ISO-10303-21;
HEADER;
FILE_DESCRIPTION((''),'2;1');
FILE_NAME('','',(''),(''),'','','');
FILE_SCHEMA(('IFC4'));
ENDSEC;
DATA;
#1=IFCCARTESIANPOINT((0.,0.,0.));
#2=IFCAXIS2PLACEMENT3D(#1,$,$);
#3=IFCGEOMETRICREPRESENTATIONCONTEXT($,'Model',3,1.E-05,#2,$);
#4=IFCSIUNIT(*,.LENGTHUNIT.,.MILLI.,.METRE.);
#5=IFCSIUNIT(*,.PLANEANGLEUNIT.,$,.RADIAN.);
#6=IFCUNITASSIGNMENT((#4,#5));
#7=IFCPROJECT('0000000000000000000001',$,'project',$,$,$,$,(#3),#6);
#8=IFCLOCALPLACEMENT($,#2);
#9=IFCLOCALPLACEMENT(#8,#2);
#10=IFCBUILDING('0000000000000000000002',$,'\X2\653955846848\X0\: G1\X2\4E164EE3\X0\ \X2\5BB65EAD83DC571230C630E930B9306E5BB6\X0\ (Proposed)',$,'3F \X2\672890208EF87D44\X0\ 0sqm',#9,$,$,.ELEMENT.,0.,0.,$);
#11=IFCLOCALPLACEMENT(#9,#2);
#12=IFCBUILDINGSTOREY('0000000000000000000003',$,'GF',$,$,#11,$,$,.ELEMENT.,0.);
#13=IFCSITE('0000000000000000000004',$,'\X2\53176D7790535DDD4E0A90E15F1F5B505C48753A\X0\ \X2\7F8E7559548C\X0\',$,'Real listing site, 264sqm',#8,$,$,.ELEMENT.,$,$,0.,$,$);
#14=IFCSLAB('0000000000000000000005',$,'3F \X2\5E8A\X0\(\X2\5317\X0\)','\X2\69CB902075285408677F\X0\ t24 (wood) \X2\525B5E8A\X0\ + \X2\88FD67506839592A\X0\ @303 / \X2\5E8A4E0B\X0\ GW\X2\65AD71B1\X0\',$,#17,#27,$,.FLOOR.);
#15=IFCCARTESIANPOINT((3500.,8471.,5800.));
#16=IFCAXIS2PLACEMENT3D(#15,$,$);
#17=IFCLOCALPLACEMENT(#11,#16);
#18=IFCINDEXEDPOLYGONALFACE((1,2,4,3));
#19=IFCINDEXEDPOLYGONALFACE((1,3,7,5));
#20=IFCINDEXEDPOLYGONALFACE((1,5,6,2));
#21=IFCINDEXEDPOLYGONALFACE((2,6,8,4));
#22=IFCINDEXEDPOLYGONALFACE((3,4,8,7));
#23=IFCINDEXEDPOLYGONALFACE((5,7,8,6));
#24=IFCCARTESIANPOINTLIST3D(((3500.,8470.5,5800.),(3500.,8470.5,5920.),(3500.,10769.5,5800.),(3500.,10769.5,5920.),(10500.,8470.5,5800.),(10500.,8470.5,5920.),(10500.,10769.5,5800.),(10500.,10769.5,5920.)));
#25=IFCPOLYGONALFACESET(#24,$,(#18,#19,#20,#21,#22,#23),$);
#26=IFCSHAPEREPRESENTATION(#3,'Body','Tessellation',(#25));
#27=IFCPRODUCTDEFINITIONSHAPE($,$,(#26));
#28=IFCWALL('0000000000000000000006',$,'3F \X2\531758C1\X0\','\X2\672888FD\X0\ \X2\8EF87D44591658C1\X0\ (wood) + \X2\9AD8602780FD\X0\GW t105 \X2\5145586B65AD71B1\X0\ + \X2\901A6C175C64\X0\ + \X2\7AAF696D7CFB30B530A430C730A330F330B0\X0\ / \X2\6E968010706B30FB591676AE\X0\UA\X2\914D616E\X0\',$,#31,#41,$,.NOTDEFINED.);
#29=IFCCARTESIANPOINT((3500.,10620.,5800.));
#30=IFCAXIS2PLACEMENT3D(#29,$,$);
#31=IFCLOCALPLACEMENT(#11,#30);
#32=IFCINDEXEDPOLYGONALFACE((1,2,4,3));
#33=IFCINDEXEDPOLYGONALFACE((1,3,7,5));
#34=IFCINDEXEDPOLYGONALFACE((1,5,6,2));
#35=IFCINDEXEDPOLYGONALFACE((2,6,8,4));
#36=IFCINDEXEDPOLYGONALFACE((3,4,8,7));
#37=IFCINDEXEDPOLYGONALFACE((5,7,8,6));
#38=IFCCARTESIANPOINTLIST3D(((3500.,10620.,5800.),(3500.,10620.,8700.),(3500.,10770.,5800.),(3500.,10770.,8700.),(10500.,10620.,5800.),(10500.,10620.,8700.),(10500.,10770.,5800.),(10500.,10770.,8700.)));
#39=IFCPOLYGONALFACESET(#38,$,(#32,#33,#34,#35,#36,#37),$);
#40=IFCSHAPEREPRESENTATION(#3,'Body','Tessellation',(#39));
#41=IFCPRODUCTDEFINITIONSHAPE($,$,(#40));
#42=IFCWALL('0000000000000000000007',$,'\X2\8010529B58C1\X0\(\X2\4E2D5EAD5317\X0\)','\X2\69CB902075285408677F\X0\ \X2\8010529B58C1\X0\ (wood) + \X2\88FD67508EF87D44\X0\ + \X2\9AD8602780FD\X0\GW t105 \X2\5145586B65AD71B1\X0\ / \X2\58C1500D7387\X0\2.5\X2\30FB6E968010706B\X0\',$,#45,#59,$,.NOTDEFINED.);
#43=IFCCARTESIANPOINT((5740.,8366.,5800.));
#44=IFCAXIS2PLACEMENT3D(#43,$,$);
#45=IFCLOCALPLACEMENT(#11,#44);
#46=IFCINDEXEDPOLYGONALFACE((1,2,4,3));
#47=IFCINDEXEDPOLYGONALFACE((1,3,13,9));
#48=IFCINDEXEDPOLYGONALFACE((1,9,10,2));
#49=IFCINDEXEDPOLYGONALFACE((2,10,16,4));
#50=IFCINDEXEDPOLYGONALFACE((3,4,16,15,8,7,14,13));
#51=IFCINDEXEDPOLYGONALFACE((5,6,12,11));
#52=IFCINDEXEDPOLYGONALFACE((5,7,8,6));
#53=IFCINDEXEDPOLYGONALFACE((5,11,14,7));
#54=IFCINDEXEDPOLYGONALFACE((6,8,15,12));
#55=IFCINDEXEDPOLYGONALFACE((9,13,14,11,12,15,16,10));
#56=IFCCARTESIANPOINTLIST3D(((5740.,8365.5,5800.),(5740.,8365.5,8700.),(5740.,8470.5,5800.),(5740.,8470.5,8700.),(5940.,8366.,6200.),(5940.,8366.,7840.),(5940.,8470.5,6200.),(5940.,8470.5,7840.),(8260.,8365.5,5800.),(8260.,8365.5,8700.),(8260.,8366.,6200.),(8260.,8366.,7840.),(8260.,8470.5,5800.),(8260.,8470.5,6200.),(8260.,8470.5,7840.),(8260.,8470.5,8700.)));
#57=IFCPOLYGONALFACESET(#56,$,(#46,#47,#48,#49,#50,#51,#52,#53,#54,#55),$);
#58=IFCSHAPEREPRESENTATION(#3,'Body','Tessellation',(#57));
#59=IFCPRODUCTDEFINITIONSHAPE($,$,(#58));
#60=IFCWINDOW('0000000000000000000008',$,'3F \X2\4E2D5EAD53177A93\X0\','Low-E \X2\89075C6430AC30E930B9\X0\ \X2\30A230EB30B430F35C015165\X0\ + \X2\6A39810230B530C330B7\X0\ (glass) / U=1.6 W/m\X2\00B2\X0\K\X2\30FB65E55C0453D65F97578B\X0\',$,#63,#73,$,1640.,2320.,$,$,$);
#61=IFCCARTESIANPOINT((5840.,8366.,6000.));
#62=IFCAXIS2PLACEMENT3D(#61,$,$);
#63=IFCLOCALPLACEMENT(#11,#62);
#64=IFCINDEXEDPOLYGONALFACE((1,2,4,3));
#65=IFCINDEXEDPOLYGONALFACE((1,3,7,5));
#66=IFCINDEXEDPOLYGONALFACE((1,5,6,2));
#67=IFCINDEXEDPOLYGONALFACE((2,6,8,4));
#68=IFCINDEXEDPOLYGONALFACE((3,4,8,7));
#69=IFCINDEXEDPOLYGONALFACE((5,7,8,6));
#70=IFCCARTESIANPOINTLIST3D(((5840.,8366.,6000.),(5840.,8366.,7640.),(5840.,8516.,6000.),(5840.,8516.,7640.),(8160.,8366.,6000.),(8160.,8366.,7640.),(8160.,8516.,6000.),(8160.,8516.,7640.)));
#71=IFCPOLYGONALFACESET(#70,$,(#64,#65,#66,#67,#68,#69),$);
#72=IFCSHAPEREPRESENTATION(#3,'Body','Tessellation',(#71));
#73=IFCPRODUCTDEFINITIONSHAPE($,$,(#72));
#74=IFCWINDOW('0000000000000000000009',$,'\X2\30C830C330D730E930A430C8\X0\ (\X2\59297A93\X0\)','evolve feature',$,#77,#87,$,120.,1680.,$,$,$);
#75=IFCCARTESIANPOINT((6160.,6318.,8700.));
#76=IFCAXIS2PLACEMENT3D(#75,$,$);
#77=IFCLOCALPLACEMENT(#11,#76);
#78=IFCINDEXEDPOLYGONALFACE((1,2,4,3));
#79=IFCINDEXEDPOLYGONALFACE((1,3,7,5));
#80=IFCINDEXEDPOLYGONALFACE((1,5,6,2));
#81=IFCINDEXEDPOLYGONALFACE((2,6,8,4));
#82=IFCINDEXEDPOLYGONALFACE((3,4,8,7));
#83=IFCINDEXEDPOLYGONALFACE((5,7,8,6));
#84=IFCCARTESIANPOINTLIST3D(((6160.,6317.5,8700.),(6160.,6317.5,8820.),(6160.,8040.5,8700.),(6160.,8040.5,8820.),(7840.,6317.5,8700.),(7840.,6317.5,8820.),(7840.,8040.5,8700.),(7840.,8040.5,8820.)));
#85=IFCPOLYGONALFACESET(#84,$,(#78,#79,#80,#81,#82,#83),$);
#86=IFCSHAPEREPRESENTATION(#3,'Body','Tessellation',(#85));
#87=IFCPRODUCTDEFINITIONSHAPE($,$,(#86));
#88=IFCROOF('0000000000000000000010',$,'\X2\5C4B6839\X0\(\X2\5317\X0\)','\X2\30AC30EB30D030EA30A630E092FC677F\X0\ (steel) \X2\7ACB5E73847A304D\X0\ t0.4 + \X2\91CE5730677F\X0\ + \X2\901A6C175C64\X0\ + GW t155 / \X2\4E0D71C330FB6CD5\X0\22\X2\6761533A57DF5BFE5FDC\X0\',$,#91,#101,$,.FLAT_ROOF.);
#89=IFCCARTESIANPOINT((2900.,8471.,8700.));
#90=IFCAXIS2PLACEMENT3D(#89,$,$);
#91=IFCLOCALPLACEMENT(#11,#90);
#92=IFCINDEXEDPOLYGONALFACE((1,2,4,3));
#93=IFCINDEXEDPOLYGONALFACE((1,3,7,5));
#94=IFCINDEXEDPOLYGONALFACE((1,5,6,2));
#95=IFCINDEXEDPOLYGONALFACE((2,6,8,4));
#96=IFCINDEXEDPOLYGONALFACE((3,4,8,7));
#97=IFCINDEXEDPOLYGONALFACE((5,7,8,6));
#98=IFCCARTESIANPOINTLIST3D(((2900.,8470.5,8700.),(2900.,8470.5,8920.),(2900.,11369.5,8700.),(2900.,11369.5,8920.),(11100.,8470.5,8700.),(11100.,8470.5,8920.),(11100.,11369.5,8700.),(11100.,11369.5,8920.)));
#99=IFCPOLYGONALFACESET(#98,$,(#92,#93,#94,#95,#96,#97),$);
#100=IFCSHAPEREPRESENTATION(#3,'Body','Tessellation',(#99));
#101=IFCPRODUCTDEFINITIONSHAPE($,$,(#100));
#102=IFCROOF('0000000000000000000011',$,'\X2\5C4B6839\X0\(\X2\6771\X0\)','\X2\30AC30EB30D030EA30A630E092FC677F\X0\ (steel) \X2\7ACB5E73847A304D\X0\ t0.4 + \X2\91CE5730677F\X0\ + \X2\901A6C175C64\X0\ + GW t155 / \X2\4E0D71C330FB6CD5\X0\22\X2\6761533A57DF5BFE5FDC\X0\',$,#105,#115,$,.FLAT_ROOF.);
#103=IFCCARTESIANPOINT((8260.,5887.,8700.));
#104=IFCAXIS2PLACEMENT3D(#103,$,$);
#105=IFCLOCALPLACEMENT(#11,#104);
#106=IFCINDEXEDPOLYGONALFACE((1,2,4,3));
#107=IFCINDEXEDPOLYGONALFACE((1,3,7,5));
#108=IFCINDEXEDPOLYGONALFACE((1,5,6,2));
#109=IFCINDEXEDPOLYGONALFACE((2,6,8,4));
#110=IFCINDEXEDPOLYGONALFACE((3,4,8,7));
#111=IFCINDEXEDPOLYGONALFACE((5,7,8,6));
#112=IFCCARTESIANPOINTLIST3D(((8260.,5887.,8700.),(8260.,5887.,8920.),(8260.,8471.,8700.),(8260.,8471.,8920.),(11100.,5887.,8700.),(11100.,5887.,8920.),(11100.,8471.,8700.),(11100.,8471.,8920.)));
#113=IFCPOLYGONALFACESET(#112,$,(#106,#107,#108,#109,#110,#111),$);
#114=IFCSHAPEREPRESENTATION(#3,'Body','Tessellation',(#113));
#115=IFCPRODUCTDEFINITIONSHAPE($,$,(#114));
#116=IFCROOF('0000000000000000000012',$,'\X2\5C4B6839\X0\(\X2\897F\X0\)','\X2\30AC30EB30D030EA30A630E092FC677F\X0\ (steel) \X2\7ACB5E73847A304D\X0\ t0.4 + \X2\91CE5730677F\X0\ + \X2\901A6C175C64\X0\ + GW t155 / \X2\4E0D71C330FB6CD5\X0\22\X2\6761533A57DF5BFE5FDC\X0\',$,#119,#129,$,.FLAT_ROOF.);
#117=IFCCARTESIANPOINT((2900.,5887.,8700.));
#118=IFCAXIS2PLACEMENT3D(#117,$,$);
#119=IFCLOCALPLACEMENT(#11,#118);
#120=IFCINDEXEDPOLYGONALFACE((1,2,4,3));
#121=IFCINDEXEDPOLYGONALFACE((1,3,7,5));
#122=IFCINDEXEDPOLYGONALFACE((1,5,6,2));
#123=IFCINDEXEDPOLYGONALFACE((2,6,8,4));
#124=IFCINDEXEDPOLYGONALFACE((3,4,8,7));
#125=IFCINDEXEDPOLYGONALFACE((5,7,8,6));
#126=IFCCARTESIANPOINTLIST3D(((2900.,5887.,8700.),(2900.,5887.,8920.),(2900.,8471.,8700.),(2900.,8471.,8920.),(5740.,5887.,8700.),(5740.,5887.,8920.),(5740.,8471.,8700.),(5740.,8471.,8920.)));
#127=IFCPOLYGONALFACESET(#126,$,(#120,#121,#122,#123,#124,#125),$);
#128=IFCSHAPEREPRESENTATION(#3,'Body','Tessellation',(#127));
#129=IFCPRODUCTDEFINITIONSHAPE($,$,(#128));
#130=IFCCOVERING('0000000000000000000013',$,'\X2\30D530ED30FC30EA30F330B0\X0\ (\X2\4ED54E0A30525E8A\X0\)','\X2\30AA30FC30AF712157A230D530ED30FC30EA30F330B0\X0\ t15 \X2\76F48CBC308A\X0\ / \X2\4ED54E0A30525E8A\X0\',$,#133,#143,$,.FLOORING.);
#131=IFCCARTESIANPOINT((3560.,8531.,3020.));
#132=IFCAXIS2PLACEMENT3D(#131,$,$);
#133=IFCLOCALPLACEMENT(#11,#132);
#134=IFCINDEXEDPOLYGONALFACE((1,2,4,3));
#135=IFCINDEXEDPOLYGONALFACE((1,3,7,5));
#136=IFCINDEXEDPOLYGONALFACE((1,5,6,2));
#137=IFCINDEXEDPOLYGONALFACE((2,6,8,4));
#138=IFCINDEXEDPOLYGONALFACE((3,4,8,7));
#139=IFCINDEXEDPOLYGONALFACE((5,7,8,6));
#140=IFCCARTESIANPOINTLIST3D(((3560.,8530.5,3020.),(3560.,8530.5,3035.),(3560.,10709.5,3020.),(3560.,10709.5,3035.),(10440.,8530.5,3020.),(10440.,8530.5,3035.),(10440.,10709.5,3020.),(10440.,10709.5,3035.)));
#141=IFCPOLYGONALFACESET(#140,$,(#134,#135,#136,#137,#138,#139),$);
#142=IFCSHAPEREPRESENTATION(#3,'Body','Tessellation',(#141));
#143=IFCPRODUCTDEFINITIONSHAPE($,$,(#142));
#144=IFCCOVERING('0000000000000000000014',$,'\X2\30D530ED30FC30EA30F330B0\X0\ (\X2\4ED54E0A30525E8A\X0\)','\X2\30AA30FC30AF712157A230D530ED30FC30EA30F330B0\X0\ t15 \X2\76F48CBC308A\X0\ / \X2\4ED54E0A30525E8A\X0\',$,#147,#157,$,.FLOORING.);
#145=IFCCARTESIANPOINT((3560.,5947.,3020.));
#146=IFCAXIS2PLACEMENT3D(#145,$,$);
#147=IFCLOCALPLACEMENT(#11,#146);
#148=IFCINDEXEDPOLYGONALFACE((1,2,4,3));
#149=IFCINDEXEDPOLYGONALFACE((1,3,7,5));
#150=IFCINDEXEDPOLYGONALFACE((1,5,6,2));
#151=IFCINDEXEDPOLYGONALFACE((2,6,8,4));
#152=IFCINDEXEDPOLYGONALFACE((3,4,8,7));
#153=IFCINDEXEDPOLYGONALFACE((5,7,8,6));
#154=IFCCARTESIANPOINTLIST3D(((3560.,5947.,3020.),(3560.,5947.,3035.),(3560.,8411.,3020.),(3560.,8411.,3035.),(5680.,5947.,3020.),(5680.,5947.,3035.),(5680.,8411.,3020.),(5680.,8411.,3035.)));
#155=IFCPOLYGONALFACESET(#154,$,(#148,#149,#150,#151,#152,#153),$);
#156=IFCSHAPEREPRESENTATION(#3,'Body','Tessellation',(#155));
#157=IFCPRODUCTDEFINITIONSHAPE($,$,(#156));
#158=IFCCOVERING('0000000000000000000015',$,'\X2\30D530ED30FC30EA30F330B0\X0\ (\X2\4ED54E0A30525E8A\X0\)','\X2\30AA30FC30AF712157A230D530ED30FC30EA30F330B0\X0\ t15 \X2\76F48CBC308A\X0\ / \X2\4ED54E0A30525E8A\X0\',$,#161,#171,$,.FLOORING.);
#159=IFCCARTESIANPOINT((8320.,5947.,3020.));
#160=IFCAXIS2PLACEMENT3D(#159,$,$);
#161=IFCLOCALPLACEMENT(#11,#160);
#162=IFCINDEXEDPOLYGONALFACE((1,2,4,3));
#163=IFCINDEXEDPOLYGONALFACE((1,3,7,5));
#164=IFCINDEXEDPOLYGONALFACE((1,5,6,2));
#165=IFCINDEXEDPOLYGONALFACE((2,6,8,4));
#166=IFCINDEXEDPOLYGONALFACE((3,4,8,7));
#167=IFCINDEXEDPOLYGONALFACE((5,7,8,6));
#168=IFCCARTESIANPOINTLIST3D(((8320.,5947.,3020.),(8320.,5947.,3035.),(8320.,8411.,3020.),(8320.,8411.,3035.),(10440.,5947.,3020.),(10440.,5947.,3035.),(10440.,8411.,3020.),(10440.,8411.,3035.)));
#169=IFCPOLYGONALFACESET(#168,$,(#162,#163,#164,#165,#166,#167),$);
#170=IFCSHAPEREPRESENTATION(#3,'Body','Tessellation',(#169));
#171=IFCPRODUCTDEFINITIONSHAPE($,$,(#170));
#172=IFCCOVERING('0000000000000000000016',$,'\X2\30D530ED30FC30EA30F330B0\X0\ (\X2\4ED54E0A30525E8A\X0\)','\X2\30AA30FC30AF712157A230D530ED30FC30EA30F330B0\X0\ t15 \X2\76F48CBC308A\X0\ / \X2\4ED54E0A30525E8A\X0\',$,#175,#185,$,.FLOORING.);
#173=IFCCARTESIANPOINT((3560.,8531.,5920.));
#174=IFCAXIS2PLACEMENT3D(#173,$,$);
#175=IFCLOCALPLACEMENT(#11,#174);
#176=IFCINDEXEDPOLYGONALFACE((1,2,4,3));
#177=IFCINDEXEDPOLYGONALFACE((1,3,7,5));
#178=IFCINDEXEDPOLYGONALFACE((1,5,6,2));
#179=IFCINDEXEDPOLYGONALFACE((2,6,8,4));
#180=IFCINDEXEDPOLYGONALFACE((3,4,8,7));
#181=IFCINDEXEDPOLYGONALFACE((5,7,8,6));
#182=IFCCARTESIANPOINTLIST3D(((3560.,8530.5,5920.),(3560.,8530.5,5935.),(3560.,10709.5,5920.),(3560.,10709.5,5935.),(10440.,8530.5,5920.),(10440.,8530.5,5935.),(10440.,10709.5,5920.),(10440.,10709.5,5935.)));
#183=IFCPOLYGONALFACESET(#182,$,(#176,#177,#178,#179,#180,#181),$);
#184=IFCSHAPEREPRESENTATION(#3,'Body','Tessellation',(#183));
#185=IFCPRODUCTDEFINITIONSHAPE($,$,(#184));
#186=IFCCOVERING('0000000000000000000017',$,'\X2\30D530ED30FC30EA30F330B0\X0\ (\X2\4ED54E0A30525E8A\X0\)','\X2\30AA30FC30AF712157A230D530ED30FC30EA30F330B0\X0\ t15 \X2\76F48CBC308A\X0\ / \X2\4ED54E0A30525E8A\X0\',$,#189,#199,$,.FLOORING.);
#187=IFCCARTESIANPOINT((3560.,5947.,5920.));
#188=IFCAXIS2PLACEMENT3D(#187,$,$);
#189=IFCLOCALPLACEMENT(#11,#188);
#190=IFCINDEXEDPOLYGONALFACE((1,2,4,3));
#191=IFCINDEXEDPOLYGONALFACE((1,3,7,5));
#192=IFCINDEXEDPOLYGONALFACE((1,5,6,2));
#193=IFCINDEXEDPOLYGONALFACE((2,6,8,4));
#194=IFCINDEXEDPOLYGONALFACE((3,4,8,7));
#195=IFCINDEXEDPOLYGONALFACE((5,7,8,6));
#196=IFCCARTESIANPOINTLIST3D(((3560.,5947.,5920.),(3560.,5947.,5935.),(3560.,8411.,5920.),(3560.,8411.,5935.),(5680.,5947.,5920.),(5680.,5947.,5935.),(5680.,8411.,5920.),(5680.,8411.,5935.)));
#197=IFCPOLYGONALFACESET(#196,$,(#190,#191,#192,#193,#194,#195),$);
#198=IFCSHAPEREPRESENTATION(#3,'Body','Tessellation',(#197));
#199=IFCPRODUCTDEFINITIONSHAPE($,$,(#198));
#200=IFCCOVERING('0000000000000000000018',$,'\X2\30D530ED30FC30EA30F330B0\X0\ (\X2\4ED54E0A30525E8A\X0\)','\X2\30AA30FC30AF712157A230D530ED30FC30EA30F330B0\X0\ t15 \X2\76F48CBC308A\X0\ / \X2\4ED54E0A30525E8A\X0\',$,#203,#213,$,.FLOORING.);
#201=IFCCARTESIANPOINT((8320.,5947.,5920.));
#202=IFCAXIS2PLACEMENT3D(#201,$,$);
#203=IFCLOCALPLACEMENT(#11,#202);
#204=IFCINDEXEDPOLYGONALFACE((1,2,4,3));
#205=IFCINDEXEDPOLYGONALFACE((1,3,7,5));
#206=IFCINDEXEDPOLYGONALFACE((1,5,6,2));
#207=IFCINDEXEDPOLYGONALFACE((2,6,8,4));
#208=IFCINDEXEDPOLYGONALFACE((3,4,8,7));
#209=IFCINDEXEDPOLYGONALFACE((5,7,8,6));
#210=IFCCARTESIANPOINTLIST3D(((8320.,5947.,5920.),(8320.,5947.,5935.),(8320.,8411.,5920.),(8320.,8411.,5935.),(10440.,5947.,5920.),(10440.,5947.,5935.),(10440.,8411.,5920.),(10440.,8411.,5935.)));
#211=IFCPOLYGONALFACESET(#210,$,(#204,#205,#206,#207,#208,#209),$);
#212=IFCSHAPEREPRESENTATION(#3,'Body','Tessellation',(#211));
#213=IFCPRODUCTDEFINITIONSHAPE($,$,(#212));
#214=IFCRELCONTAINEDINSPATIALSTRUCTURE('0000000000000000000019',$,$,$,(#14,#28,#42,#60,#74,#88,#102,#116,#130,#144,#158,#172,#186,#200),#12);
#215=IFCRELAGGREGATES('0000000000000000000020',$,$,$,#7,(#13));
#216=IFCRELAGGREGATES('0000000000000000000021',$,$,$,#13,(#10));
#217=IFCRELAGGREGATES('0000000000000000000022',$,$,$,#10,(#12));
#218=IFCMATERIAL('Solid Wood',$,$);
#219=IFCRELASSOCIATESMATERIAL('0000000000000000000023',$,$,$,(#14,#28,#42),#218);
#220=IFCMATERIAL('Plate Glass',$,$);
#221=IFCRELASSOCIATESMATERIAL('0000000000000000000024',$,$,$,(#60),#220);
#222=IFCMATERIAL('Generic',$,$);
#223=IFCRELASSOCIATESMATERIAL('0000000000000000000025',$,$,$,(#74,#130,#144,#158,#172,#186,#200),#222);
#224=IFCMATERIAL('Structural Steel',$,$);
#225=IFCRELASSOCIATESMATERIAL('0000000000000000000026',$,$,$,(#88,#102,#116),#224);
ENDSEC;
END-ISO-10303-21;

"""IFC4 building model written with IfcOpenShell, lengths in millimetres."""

from ifc_helpers import new_model, si_unit, frame, frame_2d, origin, place, context, project, spatial, rectangle, extrude, material, element, fill, save


model = new_model("IFC4")

# Units and contexts
model_context = context("Model", 3, precision=1e-05, world=origin())
ifc_project = project(units=[si_unit("LENGTHUNIT", "METRE", prefix="MILLI"), si_unit("PLANEANGLEUNIT", "RADIAN")], contexts=[model_context])

# Site, building, storey
site_placement = place(None, origin())
site = spatial("IfcSite", under=ifc_project, at=site_placement, Name="北海道川上郡弟子屈町 美留和", ObjectType="Real listing site, 264sqm", CompositionType="ELEMENT", RefElevation=0.0)
building_placement = place(site_placement, origin())
building = spatial("IfcBuilding", under=site, at=building_placement, Name="改善案: G1世代 家庭菜園テラスの家 (Proposed)", ObjectType="3F 木造軸組 0sqm", CompositionType="ELEMENT", ElevationOfRefHeight=0.0, ElevationOfTerrain=0.0)
storey_placement = place(building_placement, origin())
storey = spatial("IfcBuildingStorey", under=building, at=storey_placement, Name="GF", CompositionType="ELEMENT", Elevation=0.0)

# Slab
ifc_material_1 = material(Name="Solid Wood")
slab_placement = place(storey_placement, frame((3500.0, 8471.0, 5800.0)))
element("IfcSlab", 1, at=slab_placement, inside=storey, material=ifc_material_1, Name="3F 床(北)", Description="構造用合板 t24 (wood) 剛床 + 製材根太 @303 / 床下 GW断熱", PredefinedType="FLOOR", context=model_context, shape_type="SweptSolid", body=[
    extrude(rectangle(XDim=7000.0, YDim=2299.0, at=frame_2d((3500.0, 1149.0))), frame((3500.0, 8471.0, 5800.0)), (0.0, 0.0, 1.0), 120.0),
])

# Wall
wall_1_placement = place(storey_placement, frame((3500.0, 10620.0, 5800.0)))
element("IfcWall", 2, at=wall_1_placement, inside=storey, material=ifc_material_1, Name="3F 北壁", Description="木製 軸組外壁 (wood) + 高性能GW t105 充填断熱 + 通気層 + 窯業系サイディング / 準耐火・外皮UA配慮", PredefinedType="NOTDEFINED", context=model_context, shape_type="SweptSolid", body=[
    extrude(rectangle(XDim=7000.0, YDim=150.0, at=frame_2d((3500.0, 75.0))), frame((3500.0, 10620.0, 5800.0)), (0.0, 0.0, 1.0), 2900.0),
])

# Wall, opening, window
wall_2_placement = place(storey_placement, frame((5740.0, 8366.0, 5800.0)))
wall_2 = element("IfcWall", 3, at=wall_2_placement, inside=storey, material=ifc_material_1, Name="耐力壁(中庭北)", Description="構造用合板 耐力壁 (wood) + 製材軸組 + 高性能GW t105 充填断熱 / 壁倍率2.5・準耐火", PredefinedType="NOTDEFINED", context=model_context, shape_type="SweptSolid", body=[
    extrude(rectangle(XDim=2520.0, YDim=105.0, at=frame_2d((1260.0, 52.0))), frame((5740.0, 8366.0, 5800.0)), (0.0, 0.0, 1.0), 2900.0),
])
opening_placement = place(storey_placement, frame((5840.0, 8366.0, 6000.0)))
opening = element("IfcOpeningElement", 4, at=opening_placement, cuts=wall_2, PredefinedType="NOTDEFINED", context=model_context, shape_type="SweptSolid", body=[
    extrude(rectangle(XDim=2320.0, YDim=150.0, at=frame_2d((1160.0, 75.0))), frame((5840.0, 8366.0, 6000.0)), (0.0, 0.0, 1.0), 1640.0),
])
ifc_material_2 = material(Name="Plate Glass")
window_1_placement = place(storey_placement, frame((5840.0, 8366.0, 6000.0)))
window_1 = element("IfcWindow", 5, at=window_1_placement, inside=storey, material=ifc_material_2, Name="3F 中庭北窓", Description="Low-E 複層ガラス アルゴン封入 + 樹脂サッシ (glass) / U=1.6 W/m²K・日射取得型", OverallHeight=1640.0, OverallWidth=2320.0, context=model_context, shape_type="SweptSolid", body=[
    extrude(rectangle(XDim=2320.0, YDim=150.0, at=frame_2d((1160.0, 75.0))), frame((5840.0, 8366.0, 6000.0)), (0.0, 0.0, 1.0), 1640.0),
])
fill(opening, window_1)

# Window
ifc_material_3 = material(Name="Generic")
window_2_placement = place(storey_placement, frame((6160.0, 6318.0, 8700.0)))
element("IfcWindow", 6, at=window_2_placement, inside=storey, material=ifc_material_3, Name="トップライト (天窓)", Description="evolve feature", OverallHeight=120.0, OverallWidth=1680.0, context=model_context, shape_type="SweptSolid", body=[
    extrude(rectangle(XDim=1680.0, YDim=1723.0, at=frame_2d((840.0, 861.0))), frame((6160.0, 6318.0, 8700.0)), (0.0, 0.0, 1.0), 120.0),
])

# Roofs
ifc_material_4 = material(Name="Structural Steel")
roof_1_placement = place(storey_placement, frame((2900.0, 8471.0, 8700.0)))
element("IfcRoof", 7, at=roof_1_placement, inside=storey, material=ifc_material_4, Name="屋根(北)", Description="ガルバリウム鋼板 (steel) 立平葺き t0.4 + 野地板 + 通気層 + GW t155 / 不燃・法22条区域対応", PredefinedType="FLAT_ROOF", context=model_context, shape_type="SweptSolid", body=[
    extrude(rectangle(XDim=8200.0, YDim=2899.0, at=frame_2d((4100.0, 1449.0))), frame((2900.0, 8471.0, 8700.0)), (0.0, 0.0, 1.0), 220.0),
])
roof_2_placement = place(storey_placement, frame((8260.0, 5887.0, 8700.0)))
element("IfcRoof", 8, at=roof_2_placement, inside=storey, material=ifc_material_4, Name="屋根(東)", Description="ガルバリウム鋼板 (steel) 立平葺き t0.4 + 野地板 + 通気層 + GW t155 / 不燃・法22条区域対応", PredefinedType="FLAT_ROOF", context=model_context, shape_type="SweptSolid", body=[
    extrude(rectangle(XDim=2840.0, YDim=2584.0, at=frame_2d((1420.0, 1292.0))), frame((8260.0, 5887.0, 8700.0)), (0.0, 0.0, 1.0), 220.0),
])
roof_3_placement = place(storey_placement, frame((2900.0, 5887.0, 8700.0)))
element("IfcRoof", 9, at=roof_3_placement, inside=storey, material=ifc_material_4, Name="屋根(西)", Description="ガルバリウム鋼板 (steel) 立平葺き t0.4 + 野地板 + 通気層 + GW t155 / 不燃・法22条区域対応", PredefinedType="FLAT_ROOF", context=model_context, shape_type="SweptSolid", body=[
    extrude(rectangle(XDim=2840.0, YDim=2584.0, at=frame_2d((1420.0, 1292.0))), frame((2900.0, 5887.0, 8700.0)), (0.0, 0.0, 1.0), 220.0),
])

# Coverings
covering_1_placement = place(storey_placement, frame((3560.0, 8531.0, 3020.0)))
element("IfcCovering", 10, at=covering_1_placement, inside=storey, material=ifc_material_3, Name="フローリング (仕上げ床)", Description="オーク無垢フローリング t15 直貼り / 仕上げ床", PredefinedType="FLOORING", context=model_context, shape_type="SweptSolid", body=[
    extrude(rectangle(XDim=6880.0, YDim=2179.0, at=frame_2d((3440.0, 1089.0))), frame((3560.0, 8531.0, 3020.0)), (0.0, 0.0, 1.0), 15.0),
])
covering_2_placement = place(storey_placement, frame((3560.0, 5947.0, 3020.0)))
element("IfcCovering", 11, at=covering_2_placement, inside=storey, material=ifc_material_3, Name="フローリング (仕上げ床)", Description="オーク無垢フローリング t15 直貼り / 仕上げ床", PredefinedType="FLOORING", context=model_context, shape_type="SweptSolid", body=[
    extrude(rectangle(XDim=2120.0, YDim=2464.0, at=frame_2d((1060.0, 1232.0))), frame((3560.0, 5947.0, 3020.0)), (0.0, 0.0, 1.0), 15.0),
])
covering_3_placement = place(storey_placement, frame((8320.0, 5947.0, 3020.0)))
element("IfcCovering", 12, at=covering_3_placement, inside=storey, material=ifc_material_3, Name="フローリング (仕上げ床)", Description="オーク無垢フローリング t15 直貼り / 仕上げ床", PredefinedType="FLOORING", context=model_context, shape_type="SweptSolid", body=[
    extrude(rectangle(XDim=2120.0, YDim=2464.0, at=frame_2d((1060.0, 1232.0))), frame((8320.0, 5947.0, 3020.0)), (0.0, 0.0, 1.0), 15.0),
])
covering_4_placement = place(storey_placement, frame((3560.0, 8531.0, 5920.0)))
element("IfcCovering", 13, at=covering_4_placement, inside=storey, material=ifc_material_3, Name="フローリング (仕上げ床)", Description="オーク無垢フローリング t15 直貼り / 仕上げ床", PredefinedType="FLOORING", context=model_context, shape_type="SweptSolid", body=[
    extrude(rectangle(XDim=6880.0, YDim=2179.0, at=frame_2d((3440.0, 1089.0))), frame((3560.0, 8531.0, 5920.0)), (0.0, 0.0, 1.0), 15.0),
])
covering_5_placement = place(storey_placement, frame((3560.0, 5947.0, 5920.0)))
element("IfcCovering", 14, at=covering_5_placement, inside=storey, material=ifc_material_3, Name="フローリング (仕上げ床)", Description="オーク無垢フローリング t15 直貼り / 仕上げ床", PredefinedType="FLOORING", context=model_context, shape_type="SweptSolid", body=[
    extrude(rectangle(XDim=2120.0, YDim=2464.0, at=frame_2d((1060.0, 1232.0))), frame((3560.0, 5947.0, 5920.0)), (0.0, 0.0, 1.0), 15.0),
])
covering_6_placement = place(storey_placement, frame((8320.0, 5947.0, 5920.0)))
element("IfcCovering", 15, at=covering_6_placement, inside=storey, material=ifc_material_3, Name="フローリング (仕上げ床)", Description="オーク無垢フローリング t15 直貼り / 仕上げ床", PredefinedType="FLOORING", context=model_context, shape_type="SweptSolid", body=[
    extrude(rectangle(XDim=2120.0, YDim=2464.0, at=frame_2d((1060.0, 1232.0))), frame((8320.0, 5947.0, 5920.0)), (0.0, 0.0, 1.0), 15.0),
])

save(model, "model.ifc")
